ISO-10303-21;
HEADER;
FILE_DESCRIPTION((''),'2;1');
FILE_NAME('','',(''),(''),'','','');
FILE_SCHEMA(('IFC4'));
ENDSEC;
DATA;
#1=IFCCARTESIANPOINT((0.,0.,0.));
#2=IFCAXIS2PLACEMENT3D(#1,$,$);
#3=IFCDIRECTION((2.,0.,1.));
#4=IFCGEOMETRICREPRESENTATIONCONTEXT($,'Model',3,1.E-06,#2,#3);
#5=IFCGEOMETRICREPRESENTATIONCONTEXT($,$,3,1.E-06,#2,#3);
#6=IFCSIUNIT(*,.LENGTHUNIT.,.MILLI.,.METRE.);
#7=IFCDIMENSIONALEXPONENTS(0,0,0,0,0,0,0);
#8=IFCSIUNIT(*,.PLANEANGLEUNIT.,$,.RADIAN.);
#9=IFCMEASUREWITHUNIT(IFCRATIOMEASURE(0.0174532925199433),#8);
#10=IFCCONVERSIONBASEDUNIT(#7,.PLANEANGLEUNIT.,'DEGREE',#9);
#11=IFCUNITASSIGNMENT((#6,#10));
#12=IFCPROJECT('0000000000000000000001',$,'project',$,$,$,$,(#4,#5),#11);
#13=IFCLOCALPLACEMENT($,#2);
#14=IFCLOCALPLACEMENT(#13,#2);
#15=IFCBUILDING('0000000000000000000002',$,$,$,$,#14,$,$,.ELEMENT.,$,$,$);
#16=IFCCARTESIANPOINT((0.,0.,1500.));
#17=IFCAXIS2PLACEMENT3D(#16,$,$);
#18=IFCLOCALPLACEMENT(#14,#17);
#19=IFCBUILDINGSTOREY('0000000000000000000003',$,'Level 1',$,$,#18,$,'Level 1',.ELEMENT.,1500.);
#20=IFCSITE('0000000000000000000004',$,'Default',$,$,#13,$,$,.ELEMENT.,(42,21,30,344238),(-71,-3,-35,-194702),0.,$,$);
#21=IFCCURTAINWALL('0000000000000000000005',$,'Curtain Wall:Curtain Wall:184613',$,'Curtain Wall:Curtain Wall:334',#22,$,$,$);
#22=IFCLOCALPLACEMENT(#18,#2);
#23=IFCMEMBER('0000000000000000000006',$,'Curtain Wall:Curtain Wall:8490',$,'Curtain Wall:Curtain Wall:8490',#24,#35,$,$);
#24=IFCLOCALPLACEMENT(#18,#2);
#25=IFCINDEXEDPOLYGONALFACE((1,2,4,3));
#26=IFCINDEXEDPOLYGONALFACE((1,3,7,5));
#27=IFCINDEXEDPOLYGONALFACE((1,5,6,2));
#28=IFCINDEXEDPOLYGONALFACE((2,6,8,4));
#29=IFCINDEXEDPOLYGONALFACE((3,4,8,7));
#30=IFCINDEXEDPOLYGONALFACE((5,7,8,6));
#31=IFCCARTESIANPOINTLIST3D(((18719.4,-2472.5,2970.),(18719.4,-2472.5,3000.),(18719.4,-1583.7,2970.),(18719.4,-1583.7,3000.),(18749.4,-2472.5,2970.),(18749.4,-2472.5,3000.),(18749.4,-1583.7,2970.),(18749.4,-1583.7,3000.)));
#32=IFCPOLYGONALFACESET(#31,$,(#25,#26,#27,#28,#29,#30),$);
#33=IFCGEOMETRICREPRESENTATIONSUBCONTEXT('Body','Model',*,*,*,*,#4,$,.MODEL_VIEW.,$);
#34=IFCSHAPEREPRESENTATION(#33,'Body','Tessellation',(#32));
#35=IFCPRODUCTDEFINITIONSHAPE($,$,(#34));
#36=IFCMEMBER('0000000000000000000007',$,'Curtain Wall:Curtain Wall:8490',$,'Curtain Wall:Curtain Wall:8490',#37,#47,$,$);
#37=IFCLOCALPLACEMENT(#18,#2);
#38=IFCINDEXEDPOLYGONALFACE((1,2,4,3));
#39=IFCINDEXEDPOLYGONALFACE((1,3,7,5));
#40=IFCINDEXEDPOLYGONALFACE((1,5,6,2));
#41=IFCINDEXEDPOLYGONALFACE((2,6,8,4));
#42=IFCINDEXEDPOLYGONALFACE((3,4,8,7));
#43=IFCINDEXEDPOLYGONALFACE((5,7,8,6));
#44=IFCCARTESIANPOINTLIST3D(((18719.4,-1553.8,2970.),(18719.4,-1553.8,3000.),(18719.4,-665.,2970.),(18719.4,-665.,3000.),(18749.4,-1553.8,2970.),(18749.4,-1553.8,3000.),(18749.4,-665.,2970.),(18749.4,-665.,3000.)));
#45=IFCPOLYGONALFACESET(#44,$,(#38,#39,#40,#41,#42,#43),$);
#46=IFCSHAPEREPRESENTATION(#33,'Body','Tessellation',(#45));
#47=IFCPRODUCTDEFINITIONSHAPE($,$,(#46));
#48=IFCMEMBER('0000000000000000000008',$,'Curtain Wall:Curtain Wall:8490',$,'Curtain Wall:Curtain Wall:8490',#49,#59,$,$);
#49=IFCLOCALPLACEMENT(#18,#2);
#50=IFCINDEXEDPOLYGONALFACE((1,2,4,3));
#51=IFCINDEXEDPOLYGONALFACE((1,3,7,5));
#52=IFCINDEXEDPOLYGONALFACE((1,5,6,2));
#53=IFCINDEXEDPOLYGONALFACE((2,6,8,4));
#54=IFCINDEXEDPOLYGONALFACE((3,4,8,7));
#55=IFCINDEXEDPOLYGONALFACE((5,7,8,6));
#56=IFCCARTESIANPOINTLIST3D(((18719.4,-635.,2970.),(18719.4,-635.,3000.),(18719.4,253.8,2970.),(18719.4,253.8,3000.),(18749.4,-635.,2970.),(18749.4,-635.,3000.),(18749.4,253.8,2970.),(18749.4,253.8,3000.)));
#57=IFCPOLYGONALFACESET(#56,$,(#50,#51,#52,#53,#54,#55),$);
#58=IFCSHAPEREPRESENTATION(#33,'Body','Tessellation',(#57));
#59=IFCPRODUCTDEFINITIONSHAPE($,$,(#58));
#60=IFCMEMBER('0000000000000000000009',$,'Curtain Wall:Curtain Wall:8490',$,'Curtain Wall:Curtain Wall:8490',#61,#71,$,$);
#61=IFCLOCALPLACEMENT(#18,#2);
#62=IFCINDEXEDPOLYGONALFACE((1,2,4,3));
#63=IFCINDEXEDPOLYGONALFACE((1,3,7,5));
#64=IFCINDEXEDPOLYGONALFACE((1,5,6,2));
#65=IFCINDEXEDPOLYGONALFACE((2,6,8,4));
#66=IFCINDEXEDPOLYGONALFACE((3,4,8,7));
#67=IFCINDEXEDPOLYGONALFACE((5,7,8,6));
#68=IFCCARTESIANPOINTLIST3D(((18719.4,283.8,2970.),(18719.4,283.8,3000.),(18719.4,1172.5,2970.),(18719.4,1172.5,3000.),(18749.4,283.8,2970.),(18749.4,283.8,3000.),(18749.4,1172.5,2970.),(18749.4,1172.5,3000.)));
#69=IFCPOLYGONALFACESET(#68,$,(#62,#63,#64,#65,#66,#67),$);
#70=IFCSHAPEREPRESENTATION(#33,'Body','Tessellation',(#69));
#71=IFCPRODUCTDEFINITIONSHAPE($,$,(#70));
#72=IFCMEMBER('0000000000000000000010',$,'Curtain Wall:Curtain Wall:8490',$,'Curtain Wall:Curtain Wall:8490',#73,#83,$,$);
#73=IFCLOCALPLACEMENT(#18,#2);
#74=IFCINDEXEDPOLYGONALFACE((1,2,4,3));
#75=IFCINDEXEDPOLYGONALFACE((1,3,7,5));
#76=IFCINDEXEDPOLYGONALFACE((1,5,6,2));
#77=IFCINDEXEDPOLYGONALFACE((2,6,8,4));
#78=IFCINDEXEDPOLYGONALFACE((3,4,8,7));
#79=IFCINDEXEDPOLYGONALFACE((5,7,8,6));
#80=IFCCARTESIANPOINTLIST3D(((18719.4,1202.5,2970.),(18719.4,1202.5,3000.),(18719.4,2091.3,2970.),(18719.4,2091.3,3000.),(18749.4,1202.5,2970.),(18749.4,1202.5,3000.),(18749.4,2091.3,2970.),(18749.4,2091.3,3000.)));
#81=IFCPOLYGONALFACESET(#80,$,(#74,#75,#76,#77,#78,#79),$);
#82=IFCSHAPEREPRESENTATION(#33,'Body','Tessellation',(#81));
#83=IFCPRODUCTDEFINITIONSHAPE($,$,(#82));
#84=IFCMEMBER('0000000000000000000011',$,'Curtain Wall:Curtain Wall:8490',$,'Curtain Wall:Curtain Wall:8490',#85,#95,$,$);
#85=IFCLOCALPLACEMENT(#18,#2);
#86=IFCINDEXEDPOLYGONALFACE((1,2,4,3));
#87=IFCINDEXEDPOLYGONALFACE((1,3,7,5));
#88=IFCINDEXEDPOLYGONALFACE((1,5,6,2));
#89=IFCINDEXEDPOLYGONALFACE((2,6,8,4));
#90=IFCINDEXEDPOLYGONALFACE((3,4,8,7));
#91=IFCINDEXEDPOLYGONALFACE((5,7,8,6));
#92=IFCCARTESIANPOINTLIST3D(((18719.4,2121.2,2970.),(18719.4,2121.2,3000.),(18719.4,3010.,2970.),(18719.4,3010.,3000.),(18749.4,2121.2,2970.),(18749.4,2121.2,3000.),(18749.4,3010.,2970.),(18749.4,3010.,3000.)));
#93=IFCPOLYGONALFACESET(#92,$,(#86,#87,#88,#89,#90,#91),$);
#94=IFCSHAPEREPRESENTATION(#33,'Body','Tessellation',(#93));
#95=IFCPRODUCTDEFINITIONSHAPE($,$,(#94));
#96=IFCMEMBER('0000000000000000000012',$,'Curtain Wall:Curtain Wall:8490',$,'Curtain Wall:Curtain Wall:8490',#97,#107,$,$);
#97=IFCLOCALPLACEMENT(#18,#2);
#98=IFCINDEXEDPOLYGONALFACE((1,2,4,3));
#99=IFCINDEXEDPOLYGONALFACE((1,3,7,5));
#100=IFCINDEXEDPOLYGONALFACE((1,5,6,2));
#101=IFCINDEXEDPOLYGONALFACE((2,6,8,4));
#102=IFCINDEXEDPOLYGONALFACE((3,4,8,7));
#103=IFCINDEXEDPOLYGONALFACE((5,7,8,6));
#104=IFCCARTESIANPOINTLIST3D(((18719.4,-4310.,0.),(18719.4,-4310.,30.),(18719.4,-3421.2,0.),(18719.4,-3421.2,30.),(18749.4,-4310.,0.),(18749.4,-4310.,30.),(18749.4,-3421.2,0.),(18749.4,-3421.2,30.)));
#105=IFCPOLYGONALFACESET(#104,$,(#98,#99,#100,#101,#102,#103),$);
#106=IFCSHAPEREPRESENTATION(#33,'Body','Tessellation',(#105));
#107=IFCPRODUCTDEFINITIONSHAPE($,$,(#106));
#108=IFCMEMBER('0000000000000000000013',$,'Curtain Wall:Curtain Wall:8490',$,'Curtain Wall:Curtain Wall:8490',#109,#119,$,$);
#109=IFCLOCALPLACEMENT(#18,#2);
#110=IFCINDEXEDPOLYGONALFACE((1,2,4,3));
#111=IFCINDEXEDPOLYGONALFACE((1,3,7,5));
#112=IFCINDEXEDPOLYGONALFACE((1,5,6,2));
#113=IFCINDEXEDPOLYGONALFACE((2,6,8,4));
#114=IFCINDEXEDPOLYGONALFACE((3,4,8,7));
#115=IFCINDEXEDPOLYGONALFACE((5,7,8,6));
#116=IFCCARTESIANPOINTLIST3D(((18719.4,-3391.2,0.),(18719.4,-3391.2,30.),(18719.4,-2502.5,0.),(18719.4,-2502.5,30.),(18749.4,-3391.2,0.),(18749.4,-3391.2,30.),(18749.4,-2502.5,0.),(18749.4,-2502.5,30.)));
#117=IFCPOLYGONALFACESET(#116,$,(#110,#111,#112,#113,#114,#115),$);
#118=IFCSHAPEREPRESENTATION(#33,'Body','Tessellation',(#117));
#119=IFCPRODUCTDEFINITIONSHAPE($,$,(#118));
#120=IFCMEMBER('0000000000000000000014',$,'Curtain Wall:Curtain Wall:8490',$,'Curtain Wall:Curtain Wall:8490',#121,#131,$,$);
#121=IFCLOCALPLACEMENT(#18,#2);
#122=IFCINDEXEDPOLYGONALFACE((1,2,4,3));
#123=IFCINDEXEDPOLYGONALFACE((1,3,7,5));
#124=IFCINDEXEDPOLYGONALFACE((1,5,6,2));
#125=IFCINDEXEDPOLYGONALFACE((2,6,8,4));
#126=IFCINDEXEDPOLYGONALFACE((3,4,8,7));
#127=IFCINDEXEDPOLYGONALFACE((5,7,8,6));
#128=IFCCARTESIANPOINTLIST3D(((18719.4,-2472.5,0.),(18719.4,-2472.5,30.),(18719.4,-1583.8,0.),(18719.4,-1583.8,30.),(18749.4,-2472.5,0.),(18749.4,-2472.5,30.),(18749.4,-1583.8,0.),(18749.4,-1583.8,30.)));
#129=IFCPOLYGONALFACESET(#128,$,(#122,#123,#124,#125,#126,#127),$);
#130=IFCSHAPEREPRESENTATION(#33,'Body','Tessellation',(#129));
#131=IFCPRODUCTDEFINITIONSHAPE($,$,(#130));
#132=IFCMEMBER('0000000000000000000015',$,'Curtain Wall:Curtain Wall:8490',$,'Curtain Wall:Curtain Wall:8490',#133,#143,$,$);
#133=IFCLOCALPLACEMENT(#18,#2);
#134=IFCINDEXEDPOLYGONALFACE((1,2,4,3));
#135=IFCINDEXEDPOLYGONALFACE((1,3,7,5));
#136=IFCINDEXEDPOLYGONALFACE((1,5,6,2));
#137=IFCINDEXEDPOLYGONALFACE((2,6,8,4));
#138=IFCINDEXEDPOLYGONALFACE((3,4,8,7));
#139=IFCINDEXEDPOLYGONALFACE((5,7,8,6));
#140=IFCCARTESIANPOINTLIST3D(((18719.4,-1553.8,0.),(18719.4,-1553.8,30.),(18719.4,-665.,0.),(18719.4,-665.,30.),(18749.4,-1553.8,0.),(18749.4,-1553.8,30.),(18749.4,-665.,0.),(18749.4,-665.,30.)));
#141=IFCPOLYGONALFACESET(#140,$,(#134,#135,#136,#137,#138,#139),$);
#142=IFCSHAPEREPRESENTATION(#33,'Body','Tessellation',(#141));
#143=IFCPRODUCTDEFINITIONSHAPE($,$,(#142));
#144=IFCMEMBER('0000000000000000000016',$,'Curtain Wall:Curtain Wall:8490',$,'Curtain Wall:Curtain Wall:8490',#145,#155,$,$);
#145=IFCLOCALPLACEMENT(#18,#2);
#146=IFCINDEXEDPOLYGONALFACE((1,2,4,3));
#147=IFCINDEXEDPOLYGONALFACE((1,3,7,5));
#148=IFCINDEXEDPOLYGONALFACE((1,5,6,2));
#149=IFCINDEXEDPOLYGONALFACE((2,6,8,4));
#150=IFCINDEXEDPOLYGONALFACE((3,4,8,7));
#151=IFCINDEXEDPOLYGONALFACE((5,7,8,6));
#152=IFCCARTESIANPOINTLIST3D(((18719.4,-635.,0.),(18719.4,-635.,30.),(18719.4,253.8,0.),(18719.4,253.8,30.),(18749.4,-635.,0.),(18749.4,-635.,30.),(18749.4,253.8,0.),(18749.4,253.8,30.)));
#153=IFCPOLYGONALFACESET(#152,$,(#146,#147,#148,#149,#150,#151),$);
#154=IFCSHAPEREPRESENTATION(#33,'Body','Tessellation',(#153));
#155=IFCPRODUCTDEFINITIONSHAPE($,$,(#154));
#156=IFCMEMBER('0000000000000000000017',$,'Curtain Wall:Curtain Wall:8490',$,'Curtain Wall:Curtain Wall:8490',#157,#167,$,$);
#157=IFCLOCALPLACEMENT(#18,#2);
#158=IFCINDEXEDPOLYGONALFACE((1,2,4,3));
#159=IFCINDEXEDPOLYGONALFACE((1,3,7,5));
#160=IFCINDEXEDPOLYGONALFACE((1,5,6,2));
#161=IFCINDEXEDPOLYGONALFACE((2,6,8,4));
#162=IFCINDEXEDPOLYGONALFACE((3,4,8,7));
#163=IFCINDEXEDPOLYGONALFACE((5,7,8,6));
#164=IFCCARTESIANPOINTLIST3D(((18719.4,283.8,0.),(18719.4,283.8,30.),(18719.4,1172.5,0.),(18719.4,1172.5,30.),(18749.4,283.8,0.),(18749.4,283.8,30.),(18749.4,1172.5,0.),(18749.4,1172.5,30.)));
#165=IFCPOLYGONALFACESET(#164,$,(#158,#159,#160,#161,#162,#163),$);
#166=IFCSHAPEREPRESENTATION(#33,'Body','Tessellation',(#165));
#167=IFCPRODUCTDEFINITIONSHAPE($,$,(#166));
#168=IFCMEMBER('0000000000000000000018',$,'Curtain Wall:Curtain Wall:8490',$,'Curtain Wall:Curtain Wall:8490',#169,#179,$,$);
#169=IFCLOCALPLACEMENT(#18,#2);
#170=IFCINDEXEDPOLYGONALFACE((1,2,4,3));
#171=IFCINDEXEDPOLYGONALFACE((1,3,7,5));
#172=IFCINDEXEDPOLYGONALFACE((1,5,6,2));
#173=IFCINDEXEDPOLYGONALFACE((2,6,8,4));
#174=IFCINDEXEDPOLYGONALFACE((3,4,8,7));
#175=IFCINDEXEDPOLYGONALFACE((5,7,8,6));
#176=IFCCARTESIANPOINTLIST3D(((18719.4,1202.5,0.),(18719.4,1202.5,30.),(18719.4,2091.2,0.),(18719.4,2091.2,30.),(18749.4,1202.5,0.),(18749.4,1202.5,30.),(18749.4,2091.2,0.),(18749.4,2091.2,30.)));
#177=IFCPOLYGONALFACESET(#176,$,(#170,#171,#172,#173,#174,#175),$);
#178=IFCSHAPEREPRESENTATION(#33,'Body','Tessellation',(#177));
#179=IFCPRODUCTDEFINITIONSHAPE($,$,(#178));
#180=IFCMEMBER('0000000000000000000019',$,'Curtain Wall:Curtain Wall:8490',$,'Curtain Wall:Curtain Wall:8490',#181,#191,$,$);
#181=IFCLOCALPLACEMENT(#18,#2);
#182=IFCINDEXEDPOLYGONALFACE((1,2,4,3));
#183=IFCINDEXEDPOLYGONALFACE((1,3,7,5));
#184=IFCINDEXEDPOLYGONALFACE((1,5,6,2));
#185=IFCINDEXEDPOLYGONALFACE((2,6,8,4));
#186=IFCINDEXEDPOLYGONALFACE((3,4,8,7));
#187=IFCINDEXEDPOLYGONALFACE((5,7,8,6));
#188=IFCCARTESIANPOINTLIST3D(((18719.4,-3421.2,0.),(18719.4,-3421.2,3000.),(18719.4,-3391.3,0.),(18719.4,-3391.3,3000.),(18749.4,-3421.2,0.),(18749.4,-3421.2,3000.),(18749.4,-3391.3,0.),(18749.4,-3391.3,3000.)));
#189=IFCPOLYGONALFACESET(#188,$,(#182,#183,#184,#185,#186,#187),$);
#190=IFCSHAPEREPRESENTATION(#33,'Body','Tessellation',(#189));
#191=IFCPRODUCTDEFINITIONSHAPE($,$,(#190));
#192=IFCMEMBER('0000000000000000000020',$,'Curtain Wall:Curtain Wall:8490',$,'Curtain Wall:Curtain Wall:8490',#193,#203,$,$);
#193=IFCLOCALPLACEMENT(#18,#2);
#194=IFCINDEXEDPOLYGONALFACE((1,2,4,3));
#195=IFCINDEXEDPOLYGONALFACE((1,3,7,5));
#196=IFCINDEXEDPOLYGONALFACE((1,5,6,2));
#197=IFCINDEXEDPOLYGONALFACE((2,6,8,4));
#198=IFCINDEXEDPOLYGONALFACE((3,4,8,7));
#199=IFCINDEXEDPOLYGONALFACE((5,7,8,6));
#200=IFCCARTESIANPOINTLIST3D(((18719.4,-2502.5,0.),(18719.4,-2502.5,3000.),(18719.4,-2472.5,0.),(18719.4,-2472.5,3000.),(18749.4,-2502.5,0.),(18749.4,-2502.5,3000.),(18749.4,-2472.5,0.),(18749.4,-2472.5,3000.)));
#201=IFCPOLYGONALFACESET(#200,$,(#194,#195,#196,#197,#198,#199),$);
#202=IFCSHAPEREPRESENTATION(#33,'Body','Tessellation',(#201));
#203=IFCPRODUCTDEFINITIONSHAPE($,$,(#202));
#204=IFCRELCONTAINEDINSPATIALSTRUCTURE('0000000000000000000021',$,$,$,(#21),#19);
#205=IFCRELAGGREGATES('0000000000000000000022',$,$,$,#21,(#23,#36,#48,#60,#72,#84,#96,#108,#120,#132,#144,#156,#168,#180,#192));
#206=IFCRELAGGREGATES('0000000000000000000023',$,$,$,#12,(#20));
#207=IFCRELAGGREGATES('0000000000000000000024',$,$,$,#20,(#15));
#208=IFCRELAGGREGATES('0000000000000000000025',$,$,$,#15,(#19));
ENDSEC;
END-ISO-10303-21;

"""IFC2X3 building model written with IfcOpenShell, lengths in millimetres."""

from ifc_helpers import new_model, entity, si_unit, converted_unit, direction, frame, frame_2d, origin, origin_2d_with_axis, place, context, subcontext, project, spatial, rectangle, extrude, element, aggregate, save


model = new_model("IFC2X3")

# Units and contexts
model_context = context("Model", 3, precision=1e-06, world=origin(), true_north=direction((2.0, 0.0, 1.0)))
context_of_model = context(None, 3, precision=1e-06, world=origin(), true_north=direction((2.0, 0.0, 1.0)))
body_context = subcontext(model_context, "Body", "Model", "MODEL_VIEW")
ifc_project = project(units=[si_unit("LENGTHUNIT", "METRE", prefix="MILLI"), converted_unit("PLANEANGLEUNIT", "DEGREE", entity("IfcRatioMeasure", 0.0174532925199433), si_unit("PLANEANGLEUNIT", "RADIAN"), dimensions=[0, 0, 0, 0, 0, 0, 0])], contexts=[model_context, context_of_model])

# Site, building, storey
site_placement = place(None, origin())
site = spatial("IfcSite", under=ifc_project, at=site_placement, Name="Default", CompositionType="ELEMENT", RefLatitude=(42, 21, 30, 344238), RefLongitude=(-71, -3, -35, -194702), RefElevation=0.0)
building_placement = place(site_placement, origin())
building = spatial("IfcBuilding", under=site, at=building_placement, CompositionType="ELEMENT")
storey_placement = place(building_placement, frame((0.0, 0.0, 1500.0)))
storey = spatial("IfcBuildingStorey", under=building, at=storey_placement, Name="Level 1", LongName="Level 1", CompositionType="ELEMENT", Elevation=1500.0)

# Curtain wall, members
curtain_wall_1_placement = place(storey_placement, origin())
curtain_wall_1 = element("IfcCurtainWall", 1, at=curtain_wall_1_placement, inside=storey, Name="Curtain Wall:Curtain Wall:184613", ObjectType="Curtain Wall:Curtain Wall:334")
member_1_placement = place(storey_placement, origin())
member_1 = element("IfcMember", 2, at=member_1_placement, Name="Curtain Wall:Curtain Wall:8490", ObjectType="Curtain Wall:Curtain Wall:8490", context=body_context, shape_type="SweptSolid", body=[
    extrude(rectangle(XDim=888.8, YDim=30.0, at=frame_2d((0.0, 0.0), x_axis=(1.0, 0.0))), frame((18734.4, -2028.1, 2970.0), z_axis=(0.0, 0.0, 1.0), x_axis=(0.0, 1.0, 0.0)), (0.0, 0.0, 1.0), 30.0),
])
member_2_placement = place(storey_placement, origin())
member_2 = element("IfcMember", 3, at=member_2_placement, Name="Curtain Wall:Curtain Wall:8490", ObjectType="Curtain Wall:Curtain Wall:8490", context=body_context, shape_type="SweptSolid", body=[
    extrude(rectangle(XDim=888.8, YDim=30.0, at=frame_2d((0.0, 0.0), x_axis=(1.0, 0.0))), frame((18734.4, -1109.4, 2970.0), z_axis=(0.0, 0.0, 1.0), x_axis=(0.0, 1.0, 0.0)), (0.0, 0.0, 1.0), 30.0),
])
member_3_placement = place(storey_placement, origin())
member_3 = element("IfcMember", 4, at=member_3_placement, Name="Curtain Wall:Curtain Wall:8490", ObjectType="Curtain Wall:Curtain Wall:8490", context=body_context, shape_type="SweptSolid", body=[
    extrude(rectangle(XDim=888.8, YDim=30.0, at=origin_2d_with_axis()), frame((18734.4, -190.6, 2970.0), z_axis=(0.0, 0.0, 1.0), x_axis=(0.0, 1.0, 0.0)), (0.0, 0.0, 1.0), 30.0),
])
member_4_placement = place(storey_placement, origin())
member_4 = element("IfcMember", 5, at=member_4_placement, Name="Curtain Wall:Curtain Wall:8490", ObjectType="Curtain Wall:Curtain Wall:8490", context=body_context, shape_type="SweptSolid", body=[
    extrude(rectangle(XDim=888.8, YDim=30.0, at=frame_2d((0.0, 0.0), x_axis=(1.0, 0.0))), frame((18734.4, 728.1, 2970.0), z_axis=(0.0, 0.0, 1.0), x_axis=(0.0, 1.0, 0.0)), (0.0, 0.0, 1.0), 30.0),
])
member_5_placement = place(storey_placement, origin())
member_5 = element("IfcMember", 6, at=member_5_placement, Name="Curtain Wall:Curtain Wall:8490", ObjectType="Curtain Wall:Curtain Wall:8490", context=body_context, shape_type="SweptSolid", body=[
    extrude(rectangle(XDim=888.8, YDim=30.0, at=frame_2d((0.0, 0.0), x_axis=(1.0, 0.0))), frame((18734.4, 1646.9, 2970.0), z_axis=(0.0, 0.0, 1.0), x_axis=(0.0, 1.0, 0.0)), (0.0, 0.0, 1.0), 30.0),
])
member_6_placement = place(storey_placement, origin())
member_6 = element("IfcMember", 7, at=member_6_placement, Name="Curtain Wall:Curtain Wall:8490", ObjectType="Curtain Wall:Curtain Wall:8490", context=body_context, shape_type="SweptSolid", body=[
    extrude(rectangle(XDim=888.8, YDim=30.0, at=origin_2d_with_axis()), frame((18734.4, 2565.6, 2970.0), z_axis=(0.0, 0.0, 1.0), x_axis=(0.0, 1.0, 0.0)), (0.0, 0.0, 1.0), 30.0),
])
member_7_placement = place(storey_placement, origin())
member_7 = element("IfcMember", 8, at=member_7_placement, Name="Curtain Wall:Curtain Wall:8490", ObjectType="Curtain Wall:Curtain Wall:8490", context=body_context, shape_type="SweptSolid", body=[
    extrude(rectangle(XDim=888.8, YDim=30.0, at=frame_2d((0.0, 0.0), x_axis=(1.0, 0.0))), frame((18734.4, -3865.6, 0.0), z_axis=(0.0, 0.0, 1.0), x_axis=(0.0, -1.0, 0.0)), (0.0, 0.0, 1.0), 30.0),
])
member_8_placement = place(storey_placement, origin())
member_8 = element("IfcMember", 9, at=member_8_placement, Name="Curtain Wall:Curtain Wall:8490", ObjectType="Curtain Wall:Curtain Wall:8490", context=body_context, shape_type="SweptSolid", body=[
    extrude(rectangle(XDim=888.8, YDim=30.0, at=frame_2d((0.0, 0.0), x_axis=(1.0, 0.0))), frame((18734.4, -2946.9, 0.0), z_axis=(0.0, 0.0, 1.0), x_axis=(0.0, -1.0, 0.0)), (0.0, 0.0, 1.0), 30.0),
])
member_9_placement = place(storey_placement, origin())
member_9 = element("IfcMember", 10, at=member_9_placement, Name="Curtain Wall:Curtain Wall:8490", ObjectType="Curtain Wall:Curtain Wall:8490", context=body_context, shape_type="SweptSolid", body=[
    extrude(rectangle(XDim=888.8, YDim=30.0, at=frame_2d((0.0, 0.0), x_axis=(1.0, 0.0))), frame((18734.4, -2028.1, 0.0), z_axis=(0.0, 0.0, 1.0), x_axis=(0.0, -1.0, 0.0)), (0.0, 0.0, 1.0), 30.0),
])
member_10_placement = place(storey_placement, origin())
member_10 = element("IfcMember", 11, at=member_10_placement, Name="Curtain Wall:Curtain Wall:8490", ObjectType="Curtain Wall:Curtain Wall:8490", context=body_context, shape_type="SweptSolid", body=[
    extrude(rectangle(XDim=888.8, YDim=30.0, at=frame_2d((0.0, 0.0), x_axis=(1.0, 0.0))), frame((18734.4, -1109.4, 0.0), z_axis=(0.0, 0.0, 1.0), x_axis=(0.0, -1.0, 0.0)), (0.0, 0.0, 1.0), 30.0),
])
member_11_placement = place(storey_placement, origin())
member_11 = element("IfcMember", 12, at=member_11_placement, Name="Curtain Wall:Curtain Wall:8490", ObjectType="Curtain Wall:Curtain Wall:8490", context=body_context, shape_type="SweptSolid", body=[
    extrude(rectangle(XDim=888.8, YDim=30.0, at=frame_2d((0.0, 0.0), x_axis=(1.0, 0.0))), frame((18734.4, -190.6, 0.0), z_axis=(0.0, 0.0, 1.0), x_axis=(0.0, -1.0, 0.0)), (0.0, 0.0, 1.0), 30.0),
])
member_12_placement = place(storey_placement, origin())
member_12 = element("IfcMember", 13, at=member_12_placement, Name="Curtain Wall:Curtain Wall:8490", ObjectType="Curtain Wall:Curtain Wall:8490", context=body_context, shape_type="SweptSolid", body=[
    extrude(rectangle(XDim=888.8, YDim=30.0, at=frame_2d((0.0, 0.0), x_axis=(1.0, 0.0))), frame((18734.4, 728.1, 0.0), z_axis=(0.0, 0.0, 1.0), x_axis=(0.0, -1.0, 0.0)), (0.0, 0.0, 1.0), 30.0),
])
member_13_placement = place(storey_placement, origin())
member_13 = element("IfcMember", 14, at=member_13_placement, Name="Curtain Wall:Curtain Wall:8490", ObjectType="Curtain Wall:Curtain Wall:8490", context=body_context, shape_type="SweptSolid", body=[
    extrude(rectangle(XDim=888.8, YDim=30.0, at=frame_2d((0.0, 0.0), x_axis=(1.0, 0.0))), frame((18734.4, 1646.9, 0.0), z_axis=(0.0, 0.0, 1.0), x_axis=(0.0, -1.0, 0.0)), (0.0, 0.0, 1.0), 30.0),
])
member_14_placement = place(storey_placement, origin())
member_14 = element("IfcMember", 15, at=member_14_placement, Name="Curtain Wall:Curtain Wall:8490", ObjectType="Curtain Wall:Curtain Wall:8490", context=body_context, shape_type="SweptSolid", body=[
    extrude(rectangle(XDim=30.0, YDim=30.0, at=frame_2d((0.0, 0.0), x_axis=(1.0, 0.0))), frame((18734.4, -3406.2, 0.0)), (0.0, 0.0, 1.0), 3000.0),
])
member_15_placement = place(storey_placement, origin())
member_15 = element("IfcMember", 16, at=member_15_placement, Name="Curtain Wall:Curtain Wall:8490", ObjectType="Curtain Wall:Curtain Wall:8490", context=body_context, shape_type="SweptSolid", body=[
    extrude(rectangle(XDim=30.0, YDim=30.0, at=frame_2d((0.0, 0.0), x_axis=(1.0, 0.0))), frame((18734.4, -2487.5, 0.0)), (0.0, 0.0, 1.0), 3000.0),
])
aggregate(curtain_wall_1, [member_1, member_2, member_3, member_4, member_5, member_6, member_7, member_8, member_9, member_10, member_11, member_12, member_13, member_14, member_15])

save(model, "model.ifc")
